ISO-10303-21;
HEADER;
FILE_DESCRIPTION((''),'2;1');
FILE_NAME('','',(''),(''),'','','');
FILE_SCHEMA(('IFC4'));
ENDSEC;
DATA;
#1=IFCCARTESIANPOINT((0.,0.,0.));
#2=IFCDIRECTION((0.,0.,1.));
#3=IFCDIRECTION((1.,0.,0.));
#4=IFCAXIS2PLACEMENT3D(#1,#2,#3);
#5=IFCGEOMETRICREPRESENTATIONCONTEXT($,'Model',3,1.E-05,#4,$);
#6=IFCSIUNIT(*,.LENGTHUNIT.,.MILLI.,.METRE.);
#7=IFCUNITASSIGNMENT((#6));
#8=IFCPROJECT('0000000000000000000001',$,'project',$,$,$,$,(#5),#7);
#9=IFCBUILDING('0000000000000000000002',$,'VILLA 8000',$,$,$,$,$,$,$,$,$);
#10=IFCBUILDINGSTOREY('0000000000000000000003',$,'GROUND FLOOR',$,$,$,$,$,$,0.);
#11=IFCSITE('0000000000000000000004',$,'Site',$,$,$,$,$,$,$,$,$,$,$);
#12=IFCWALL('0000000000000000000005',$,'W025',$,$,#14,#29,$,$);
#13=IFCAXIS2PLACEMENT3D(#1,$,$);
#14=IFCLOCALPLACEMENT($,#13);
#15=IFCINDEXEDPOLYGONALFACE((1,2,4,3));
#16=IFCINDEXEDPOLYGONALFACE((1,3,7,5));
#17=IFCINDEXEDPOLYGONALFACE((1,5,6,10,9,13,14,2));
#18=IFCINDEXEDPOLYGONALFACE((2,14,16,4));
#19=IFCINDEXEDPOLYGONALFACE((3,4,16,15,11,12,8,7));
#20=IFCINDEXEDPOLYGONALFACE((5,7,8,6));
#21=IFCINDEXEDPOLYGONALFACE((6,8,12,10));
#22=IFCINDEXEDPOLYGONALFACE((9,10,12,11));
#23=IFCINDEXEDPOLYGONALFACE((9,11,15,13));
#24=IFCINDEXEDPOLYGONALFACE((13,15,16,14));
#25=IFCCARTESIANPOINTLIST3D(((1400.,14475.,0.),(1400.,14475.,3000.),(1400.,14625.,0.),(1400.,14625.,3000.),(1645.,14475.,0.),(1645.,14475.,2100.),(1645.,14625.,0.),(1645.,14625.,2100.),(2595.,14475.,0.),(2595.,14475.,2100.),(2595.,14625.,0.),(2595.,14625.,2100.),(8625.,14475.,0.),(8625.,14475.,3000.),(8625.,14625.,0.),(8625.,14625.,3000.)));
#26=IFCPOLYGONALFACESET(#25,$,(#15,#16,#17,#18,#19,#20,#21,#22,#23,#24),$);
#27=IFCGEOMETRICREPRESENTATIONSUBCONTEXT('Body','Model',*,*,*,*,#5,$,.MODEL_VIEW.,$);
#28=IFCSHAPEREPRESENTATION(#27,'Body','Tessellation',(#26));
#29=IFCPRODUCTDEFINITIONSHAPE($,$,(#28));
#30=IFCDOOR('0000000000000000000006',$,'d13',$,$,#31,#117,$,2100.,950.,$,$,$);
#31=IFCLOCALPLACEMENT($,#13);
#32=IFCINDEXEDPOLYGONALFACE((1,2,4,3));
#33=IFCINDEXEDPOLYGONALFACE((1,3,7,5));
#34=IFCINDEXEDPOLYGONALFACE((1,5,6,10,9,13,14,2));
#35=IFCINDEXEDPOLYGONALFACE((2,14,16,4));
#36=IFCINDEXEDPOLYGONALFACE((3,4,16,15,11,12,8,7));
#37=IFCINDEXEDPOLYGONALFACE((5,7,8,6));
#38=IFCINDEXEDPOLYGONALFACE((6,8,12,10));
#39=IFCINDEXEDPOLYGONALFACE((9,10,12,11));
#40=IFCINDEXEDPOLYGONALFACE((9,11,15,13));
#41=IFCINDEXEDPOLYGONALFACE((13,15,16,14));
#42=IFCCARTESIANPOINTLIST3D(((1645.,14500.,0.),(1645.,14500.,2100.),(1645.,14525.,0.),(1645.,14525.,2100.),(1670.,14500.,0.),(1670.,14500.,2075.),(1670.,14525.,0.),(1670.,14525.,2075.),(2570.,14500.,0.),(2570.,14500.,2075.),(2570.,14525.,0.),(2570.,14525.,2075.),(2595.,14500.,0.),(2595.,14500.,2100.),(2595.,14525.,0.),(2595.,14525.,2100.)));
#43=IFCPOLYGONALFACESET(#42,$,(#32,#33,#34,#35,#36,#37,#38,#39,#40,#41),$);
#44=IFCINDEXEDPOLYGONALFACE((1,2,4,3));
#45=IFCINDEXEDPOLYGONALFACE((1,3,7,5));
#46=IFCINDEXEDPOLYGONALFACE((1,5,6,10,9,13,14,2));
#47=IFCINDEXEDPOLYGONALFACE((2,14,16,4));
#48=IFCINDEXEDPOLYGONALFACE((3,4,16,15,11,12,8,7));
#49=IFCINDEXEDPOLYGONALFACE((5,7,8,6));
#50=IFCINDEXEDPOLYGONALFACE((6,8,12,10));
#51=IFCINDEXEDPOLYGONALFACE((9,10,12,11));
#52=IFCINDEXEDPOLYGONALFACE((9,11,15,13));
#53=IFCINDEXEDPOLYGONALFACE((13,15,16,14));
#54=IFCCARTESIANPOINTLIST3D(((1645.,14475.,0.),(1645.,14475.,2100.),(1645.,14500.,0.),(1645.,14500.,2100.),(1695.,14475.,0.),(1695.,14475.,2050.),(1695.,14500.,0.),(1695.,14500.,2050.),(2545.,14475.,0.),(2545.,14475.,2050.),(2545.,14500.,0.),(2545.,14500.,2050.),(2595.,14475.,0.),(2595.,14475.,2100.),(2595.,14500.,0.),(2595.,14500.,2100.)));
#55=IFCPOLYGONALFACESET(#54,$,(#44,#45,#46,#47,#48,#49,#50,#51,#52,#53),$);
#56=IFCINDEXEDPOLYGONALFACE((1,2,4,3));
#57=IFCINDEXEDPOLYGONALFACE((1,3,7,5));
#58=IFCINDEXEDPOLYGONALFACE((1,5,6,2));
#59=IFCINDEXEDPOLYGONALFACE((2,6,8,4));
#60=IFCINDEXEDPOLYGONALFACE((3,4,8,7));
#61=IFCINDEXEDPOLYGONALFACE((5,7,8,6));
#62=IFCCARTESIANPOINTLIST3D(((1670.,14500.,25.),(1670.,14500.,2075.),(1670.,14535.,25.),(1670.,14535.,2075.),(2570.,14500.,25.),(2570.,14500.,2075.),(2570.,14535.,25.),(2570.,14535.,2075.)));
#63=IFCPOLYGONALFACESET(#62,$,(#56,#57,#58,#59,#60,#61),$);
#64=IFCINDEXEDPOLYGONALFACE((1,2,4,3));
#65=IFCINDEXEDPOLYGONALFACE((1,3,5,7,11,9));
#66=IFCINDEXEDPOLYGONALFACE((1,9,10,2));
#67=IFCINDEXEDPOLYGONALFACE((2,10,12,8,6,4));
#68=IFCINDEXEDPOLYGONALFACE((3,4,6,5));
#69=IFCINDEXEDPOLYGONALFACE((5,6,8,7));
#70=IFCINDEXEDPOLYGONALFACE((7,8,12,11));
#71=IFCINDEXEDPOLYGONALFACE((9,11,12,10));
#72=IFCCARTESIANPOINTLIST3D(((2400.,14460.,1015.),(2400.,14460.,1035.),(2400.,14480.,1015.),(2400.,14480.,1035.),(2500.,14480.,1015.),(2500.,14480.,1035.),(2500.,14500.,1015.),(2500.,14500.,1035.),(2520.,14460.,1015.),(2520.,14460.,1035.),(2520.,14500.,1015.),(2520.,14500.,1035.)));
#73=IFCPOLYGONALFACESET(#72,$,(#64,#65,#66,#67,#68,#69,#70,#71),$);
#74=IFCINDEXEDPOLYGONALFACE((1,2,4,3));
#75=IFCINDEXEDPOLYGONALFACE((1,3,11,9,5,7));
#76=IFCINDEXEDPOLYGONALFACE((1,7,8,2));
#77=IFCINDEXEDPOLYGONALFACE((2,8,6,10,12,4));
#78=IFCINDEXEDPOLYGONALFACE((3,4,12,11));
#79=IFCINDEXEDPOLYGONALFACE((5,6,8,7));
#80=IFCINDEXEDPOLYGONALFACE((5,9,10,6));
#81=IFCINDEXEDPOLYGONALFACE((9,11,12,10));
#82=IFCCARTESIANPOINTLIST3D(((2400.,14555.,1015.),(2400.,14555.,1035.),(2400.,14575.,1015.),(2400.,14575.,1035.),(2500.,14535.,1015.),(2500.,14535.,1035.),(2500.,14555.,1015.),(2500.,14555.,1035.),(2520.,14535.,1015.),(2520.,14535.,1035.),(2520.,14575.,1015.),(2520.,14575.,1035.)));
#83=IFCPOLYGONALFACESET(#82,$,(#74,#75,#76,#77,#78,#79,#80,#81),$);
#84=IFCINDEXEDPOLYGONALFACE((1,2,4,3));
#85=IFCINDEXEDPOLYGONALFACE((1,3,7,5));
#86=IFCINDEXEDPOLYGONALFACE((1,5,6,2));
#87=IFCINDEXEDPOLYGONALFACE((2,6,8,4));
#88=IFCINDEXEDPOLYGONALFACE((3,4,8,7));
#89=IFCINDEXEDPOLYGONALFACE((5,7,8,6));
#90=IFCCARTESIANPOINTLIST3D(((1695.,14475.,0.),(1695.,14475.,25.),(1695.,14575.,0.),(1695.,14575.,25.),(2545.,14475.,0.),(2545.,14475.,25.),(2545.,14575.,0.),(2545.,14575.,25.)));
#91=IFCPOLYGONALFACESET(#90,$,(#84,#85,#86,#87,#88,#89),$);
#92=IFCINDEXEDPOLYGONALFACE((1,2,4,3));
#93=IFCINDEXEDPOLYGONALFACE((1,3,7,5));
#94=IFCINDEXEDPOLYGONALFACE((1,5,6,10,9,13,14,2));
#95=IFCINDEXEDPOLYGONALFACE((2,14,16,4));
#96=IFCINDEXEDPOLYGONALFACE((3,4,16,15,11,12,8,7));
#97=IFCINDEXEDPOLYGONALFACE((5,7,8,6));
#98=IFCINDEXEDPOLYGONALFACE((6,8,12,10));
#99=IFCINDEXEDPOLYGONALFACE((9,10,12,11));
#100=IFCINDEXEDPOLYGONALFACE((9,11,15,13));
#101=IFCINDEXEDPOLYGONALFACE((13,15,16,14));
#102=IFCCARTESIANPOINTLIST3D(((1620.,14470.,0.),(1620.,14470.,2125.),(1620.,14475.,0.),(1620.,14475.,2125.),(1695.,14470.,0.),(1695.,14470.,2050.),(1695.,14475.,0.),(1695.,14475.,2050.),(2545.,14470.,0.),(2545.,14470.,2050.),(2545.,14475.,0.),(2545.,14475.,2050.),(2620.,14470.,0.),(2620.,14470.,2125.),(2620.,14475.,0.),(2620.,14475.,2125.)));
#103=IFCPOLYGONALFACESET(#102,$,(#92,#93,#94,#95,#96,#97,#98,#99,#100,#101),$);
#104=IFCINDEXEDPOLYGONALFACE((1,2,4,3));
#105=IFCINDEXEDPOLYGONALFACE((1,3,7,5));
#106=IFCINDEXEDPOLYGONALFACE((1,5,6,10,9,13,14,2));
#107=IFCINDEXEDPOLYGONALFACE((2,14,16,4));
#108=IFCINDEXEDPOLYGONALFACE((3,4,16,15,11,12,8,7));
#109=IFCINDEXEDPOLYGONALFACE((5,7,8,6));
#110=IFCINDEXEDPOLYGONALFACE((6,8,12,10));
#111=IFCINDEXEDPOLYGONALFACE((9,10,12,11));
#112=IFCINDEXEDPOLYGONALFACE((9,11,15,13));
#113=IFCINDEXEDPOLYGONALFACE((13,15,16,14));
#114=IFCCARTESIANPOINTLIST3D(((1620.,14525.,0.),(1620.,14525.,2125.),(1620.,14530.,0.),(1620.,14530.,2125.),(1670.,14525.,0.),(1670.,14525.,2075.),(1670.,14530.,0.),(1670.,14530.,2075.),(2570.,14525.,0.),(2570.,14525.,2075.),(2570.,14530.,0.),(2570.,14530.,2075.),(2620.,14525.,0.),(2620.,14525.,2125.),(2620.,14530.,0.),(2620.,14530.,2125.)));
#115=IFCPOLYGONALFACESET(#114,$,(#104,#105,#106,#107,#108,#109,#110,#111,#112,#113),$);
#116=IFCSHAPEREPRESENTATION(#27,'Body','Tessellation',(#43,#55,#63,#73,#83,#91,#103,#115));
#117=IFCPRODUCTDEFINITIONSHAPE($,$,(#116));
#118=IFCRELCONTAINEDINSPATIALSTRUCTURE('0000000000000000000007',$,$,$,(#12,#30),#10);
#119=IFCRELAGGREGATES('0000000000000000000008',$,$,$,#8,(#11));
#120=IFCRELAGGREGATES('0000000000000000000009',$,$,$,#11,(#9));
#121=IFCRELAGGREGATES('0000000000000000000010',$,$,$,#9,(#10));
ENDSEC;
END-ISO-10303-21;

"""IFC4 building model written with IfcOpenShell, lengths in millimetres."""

from ifc_helpers import new_model, si_unit, frame, origin_with_axes, place, context, subcontext, project, spatial, line, indexed_curve, outline, extrude, element, fill, save


model = new_model("IFC4")

# Units and contexts
model_context = context("Model", 3, precision=1e-05, world=origin_with_axes())
body_context = subcontext(model_context, "Body", "Model", "MODEL_VIEW")
ifc_project = project(units=[si_unit("LENGTHUNIT", "METRE", prefix="MILLI")], contexts=[model_context])

# Site, building, storey
site = spatial("IfcSite", under=ifc_project, Name="Site")
building = spatial("IfcBuilding", under=site, Name="VILLA 8000")
storey = spatial("IfcBuildingStorey", under=building, Name="GROUND FLOOR", Elevation=0.0)

# Wall, opening, door
wall_1_placement = place(None, frame((1400.0, 14550.0, 0.0), z_axis=(0.0, 0.0, 1.0), x_axis=(1.0, 0.0, 0.0)))
wall_1 = element("IfcWall", 1, at=wall_1_placement, inside=storey, Name="W025", context=body_context, shape_type="SweptSolid", body=[
    extrude(outline(indexed_curve([(0.0, 0.0), (0.0, 150.0), (7225.0, 150.0), (7225.0, 0.0), (0.0, 0.0)], self_intersect=False)), frame((0.0, -75.0, 0.0), z_axis=(0.0, 0.0, 1.0), x_axis=(1.0, 0.0, 0.0)), (0.0, 0.0, 1.0), 3000.0),
])
opening_1_placement = place(wall_1_placement, frame((245.0, 0.0, 0.0), z_axis=(0.0, 0.0, 1.0), x_axis=(1.0, 0.0, 0.0)))
opening_1 = element("IfcOpeningElement", 2, at=opening_1_placement, cuts=wall_1, context=body_context, shape_type="SweptSolid", body=[
    extrude(outline(indexed_curve([(0.0, 0.0), (0.0, 250.0), (950.0, 250.0), (950.0, 0.0), (0.0, 0.0)], self_intersect=False)), frame((0.0, -125.0, 0.0), z_axis=(0.0, 0.0, 1.0), x_axis=(1.0, 0.0, 0.0)), (0.0, 0.0, 1.0), 2100.0),
])
door_1_placement = place(None, frame((1645.0, 14475.0, 0.0), z_axis=(0.0, 0.0, 1.0), x_axis=(1.0, 0.0, 0.0)))
door_1 = element("IfcDoor", 3, at=door_1_placement, inside=storey, Name="d13", OverallHeight=2100.0, OverallWidth=950.0, context=body_context, shape_type="SweptSolid", body=[
    extrude(outline(indexed_curve([(0.0, 0.0), (0.0, 2100.0), (950.0, 2100.0), (950.0, 0.0), (925.0, 0.0), (925.0, 2075.0), (25.0, 2075.0), (25.0, 0.0)], segments=[line(1, 2, 3, 4, 5, 6, 7, 8, 1)])), frame((0.0, 25.0, 0.0), z_axis=(0.0, -1.0, 0.0), x_axis=(1.0, 0.0, 0.0)), (0.0, 0.0, -1.0), 25.0),
    extrude(outline(indexed_curve([(0.0, 0.0), (0.0, 2100.0), (950.0, 2100.0), (950.0, 0.0), (900.0, 0.0), (900.0, 2050.0), (50.0, 2050.0), (50.0, 0.0)], segments=[line(1, 2, 3, 4, 5, 6, 7, 8, 1)])), frame((0.0, 0.0, 0.0), z_axis=(0.0, -1.0, 0.0), x_axis=(1.0, 0.0, 0.0)), (0.0, 0.0, -1.0), 25.0),
    extrude(outline(indexed_curve([(0.0, 0.0), (900.0, 0.0), (900.0, 35.0), (0.0, 35.0)], segments=[line(1, 2, 3, 4, 1)])), frame((25.0, 25.0, 25.0), z_axis=(0.0, 0.0, 1.0), x_axis=(1.0, 0.0, 0.0)), (0.0, 0.0, 1.0), 2050.0),
    extrude(outline(indexed_curve([(0.0, 0.0), (0.0, -40.0), (-120.0, -40.0), (-120.0, -20.0), (-20.0, -20.0), (-20.0, 0.0)], segments=[line(1, 2, 3, 4, 5, 6, 1)])), frame((875.0, 25.0, 1015.0), z_axis=(0.0, 0.0, 1.0), x_axis=(1.0, 0.0, 0.0)), (0.0, 0.0, 1.0), 20.0),
    extrude(outline(indexed_curve([(0.0, 0.0), (0.0, 40.0), (-120.0, 40.0), (-120.0, 20.0), (-20.0, 20.0), (-20.0, 0.0)], segments=[line(1, 2, 3, 4, 5, 6, 1)])), frame((875.0, 60.0, 1015.0), z_axis=(0.0, 0.0, 1.0), x_axis=(1.0, 0.0, 0.0)), (0.0, 0.0, 1.0), 20.0),
    extrude(outline(indexed_curve([(0.0, 0.0), (850.0, 0.0), (850.0, 100.0), (0.0, 100.0)], segments=[line(1, 2, 3, 4, 1)])), frame((50.0, 0.0, 0.0), z_axis=(0.0, 0.0, 1.0), x_axis=(1.0, 0.0, 0.0)), (0.0, 0.0, 1.0), 25.0),
    extrude(outline(indexed_curve([(0.0, 0.0), (0.0, 2125.0), (1000.0, 2125.0), (1000.0, 0.0), (925.0, 0.0), (925.0, 2050.0), (75.0, 2050.0), (75.0, 0.0)], segments=[line(1, 2, 3, 4, 5, 6, 7, 8, 1)])), frame((-25.0, -5.0, 0.0), z_axis=(0.0, -1.0, 0.0), x_axis=(1.0, 0.0, 0.0)), (0.0, 0.0, -1.0), 5.0),
    extrude(outline(indexed_curve([(0.0, 0.0), (0.0, 2125.0), (1000.0, 2125.0), (1000.0, 0.0), (950.0, 0.0), (950.0, 2075.0), (50.0, 2075.0), (50.0, 0.0)], segments=[line(1, 2, 3, 4, 5, 6, 7, 8, 1)])), frame((-25.0, 50.0, 0.0), z_axis=(0.0, -1.0, 0.0), x_axis=(1.0, 0.0, 0.0)), (0.0, 0.0, -1.0), 5.0),
])
fill(opening_1, door_1)

save(model, "model.ifc")
